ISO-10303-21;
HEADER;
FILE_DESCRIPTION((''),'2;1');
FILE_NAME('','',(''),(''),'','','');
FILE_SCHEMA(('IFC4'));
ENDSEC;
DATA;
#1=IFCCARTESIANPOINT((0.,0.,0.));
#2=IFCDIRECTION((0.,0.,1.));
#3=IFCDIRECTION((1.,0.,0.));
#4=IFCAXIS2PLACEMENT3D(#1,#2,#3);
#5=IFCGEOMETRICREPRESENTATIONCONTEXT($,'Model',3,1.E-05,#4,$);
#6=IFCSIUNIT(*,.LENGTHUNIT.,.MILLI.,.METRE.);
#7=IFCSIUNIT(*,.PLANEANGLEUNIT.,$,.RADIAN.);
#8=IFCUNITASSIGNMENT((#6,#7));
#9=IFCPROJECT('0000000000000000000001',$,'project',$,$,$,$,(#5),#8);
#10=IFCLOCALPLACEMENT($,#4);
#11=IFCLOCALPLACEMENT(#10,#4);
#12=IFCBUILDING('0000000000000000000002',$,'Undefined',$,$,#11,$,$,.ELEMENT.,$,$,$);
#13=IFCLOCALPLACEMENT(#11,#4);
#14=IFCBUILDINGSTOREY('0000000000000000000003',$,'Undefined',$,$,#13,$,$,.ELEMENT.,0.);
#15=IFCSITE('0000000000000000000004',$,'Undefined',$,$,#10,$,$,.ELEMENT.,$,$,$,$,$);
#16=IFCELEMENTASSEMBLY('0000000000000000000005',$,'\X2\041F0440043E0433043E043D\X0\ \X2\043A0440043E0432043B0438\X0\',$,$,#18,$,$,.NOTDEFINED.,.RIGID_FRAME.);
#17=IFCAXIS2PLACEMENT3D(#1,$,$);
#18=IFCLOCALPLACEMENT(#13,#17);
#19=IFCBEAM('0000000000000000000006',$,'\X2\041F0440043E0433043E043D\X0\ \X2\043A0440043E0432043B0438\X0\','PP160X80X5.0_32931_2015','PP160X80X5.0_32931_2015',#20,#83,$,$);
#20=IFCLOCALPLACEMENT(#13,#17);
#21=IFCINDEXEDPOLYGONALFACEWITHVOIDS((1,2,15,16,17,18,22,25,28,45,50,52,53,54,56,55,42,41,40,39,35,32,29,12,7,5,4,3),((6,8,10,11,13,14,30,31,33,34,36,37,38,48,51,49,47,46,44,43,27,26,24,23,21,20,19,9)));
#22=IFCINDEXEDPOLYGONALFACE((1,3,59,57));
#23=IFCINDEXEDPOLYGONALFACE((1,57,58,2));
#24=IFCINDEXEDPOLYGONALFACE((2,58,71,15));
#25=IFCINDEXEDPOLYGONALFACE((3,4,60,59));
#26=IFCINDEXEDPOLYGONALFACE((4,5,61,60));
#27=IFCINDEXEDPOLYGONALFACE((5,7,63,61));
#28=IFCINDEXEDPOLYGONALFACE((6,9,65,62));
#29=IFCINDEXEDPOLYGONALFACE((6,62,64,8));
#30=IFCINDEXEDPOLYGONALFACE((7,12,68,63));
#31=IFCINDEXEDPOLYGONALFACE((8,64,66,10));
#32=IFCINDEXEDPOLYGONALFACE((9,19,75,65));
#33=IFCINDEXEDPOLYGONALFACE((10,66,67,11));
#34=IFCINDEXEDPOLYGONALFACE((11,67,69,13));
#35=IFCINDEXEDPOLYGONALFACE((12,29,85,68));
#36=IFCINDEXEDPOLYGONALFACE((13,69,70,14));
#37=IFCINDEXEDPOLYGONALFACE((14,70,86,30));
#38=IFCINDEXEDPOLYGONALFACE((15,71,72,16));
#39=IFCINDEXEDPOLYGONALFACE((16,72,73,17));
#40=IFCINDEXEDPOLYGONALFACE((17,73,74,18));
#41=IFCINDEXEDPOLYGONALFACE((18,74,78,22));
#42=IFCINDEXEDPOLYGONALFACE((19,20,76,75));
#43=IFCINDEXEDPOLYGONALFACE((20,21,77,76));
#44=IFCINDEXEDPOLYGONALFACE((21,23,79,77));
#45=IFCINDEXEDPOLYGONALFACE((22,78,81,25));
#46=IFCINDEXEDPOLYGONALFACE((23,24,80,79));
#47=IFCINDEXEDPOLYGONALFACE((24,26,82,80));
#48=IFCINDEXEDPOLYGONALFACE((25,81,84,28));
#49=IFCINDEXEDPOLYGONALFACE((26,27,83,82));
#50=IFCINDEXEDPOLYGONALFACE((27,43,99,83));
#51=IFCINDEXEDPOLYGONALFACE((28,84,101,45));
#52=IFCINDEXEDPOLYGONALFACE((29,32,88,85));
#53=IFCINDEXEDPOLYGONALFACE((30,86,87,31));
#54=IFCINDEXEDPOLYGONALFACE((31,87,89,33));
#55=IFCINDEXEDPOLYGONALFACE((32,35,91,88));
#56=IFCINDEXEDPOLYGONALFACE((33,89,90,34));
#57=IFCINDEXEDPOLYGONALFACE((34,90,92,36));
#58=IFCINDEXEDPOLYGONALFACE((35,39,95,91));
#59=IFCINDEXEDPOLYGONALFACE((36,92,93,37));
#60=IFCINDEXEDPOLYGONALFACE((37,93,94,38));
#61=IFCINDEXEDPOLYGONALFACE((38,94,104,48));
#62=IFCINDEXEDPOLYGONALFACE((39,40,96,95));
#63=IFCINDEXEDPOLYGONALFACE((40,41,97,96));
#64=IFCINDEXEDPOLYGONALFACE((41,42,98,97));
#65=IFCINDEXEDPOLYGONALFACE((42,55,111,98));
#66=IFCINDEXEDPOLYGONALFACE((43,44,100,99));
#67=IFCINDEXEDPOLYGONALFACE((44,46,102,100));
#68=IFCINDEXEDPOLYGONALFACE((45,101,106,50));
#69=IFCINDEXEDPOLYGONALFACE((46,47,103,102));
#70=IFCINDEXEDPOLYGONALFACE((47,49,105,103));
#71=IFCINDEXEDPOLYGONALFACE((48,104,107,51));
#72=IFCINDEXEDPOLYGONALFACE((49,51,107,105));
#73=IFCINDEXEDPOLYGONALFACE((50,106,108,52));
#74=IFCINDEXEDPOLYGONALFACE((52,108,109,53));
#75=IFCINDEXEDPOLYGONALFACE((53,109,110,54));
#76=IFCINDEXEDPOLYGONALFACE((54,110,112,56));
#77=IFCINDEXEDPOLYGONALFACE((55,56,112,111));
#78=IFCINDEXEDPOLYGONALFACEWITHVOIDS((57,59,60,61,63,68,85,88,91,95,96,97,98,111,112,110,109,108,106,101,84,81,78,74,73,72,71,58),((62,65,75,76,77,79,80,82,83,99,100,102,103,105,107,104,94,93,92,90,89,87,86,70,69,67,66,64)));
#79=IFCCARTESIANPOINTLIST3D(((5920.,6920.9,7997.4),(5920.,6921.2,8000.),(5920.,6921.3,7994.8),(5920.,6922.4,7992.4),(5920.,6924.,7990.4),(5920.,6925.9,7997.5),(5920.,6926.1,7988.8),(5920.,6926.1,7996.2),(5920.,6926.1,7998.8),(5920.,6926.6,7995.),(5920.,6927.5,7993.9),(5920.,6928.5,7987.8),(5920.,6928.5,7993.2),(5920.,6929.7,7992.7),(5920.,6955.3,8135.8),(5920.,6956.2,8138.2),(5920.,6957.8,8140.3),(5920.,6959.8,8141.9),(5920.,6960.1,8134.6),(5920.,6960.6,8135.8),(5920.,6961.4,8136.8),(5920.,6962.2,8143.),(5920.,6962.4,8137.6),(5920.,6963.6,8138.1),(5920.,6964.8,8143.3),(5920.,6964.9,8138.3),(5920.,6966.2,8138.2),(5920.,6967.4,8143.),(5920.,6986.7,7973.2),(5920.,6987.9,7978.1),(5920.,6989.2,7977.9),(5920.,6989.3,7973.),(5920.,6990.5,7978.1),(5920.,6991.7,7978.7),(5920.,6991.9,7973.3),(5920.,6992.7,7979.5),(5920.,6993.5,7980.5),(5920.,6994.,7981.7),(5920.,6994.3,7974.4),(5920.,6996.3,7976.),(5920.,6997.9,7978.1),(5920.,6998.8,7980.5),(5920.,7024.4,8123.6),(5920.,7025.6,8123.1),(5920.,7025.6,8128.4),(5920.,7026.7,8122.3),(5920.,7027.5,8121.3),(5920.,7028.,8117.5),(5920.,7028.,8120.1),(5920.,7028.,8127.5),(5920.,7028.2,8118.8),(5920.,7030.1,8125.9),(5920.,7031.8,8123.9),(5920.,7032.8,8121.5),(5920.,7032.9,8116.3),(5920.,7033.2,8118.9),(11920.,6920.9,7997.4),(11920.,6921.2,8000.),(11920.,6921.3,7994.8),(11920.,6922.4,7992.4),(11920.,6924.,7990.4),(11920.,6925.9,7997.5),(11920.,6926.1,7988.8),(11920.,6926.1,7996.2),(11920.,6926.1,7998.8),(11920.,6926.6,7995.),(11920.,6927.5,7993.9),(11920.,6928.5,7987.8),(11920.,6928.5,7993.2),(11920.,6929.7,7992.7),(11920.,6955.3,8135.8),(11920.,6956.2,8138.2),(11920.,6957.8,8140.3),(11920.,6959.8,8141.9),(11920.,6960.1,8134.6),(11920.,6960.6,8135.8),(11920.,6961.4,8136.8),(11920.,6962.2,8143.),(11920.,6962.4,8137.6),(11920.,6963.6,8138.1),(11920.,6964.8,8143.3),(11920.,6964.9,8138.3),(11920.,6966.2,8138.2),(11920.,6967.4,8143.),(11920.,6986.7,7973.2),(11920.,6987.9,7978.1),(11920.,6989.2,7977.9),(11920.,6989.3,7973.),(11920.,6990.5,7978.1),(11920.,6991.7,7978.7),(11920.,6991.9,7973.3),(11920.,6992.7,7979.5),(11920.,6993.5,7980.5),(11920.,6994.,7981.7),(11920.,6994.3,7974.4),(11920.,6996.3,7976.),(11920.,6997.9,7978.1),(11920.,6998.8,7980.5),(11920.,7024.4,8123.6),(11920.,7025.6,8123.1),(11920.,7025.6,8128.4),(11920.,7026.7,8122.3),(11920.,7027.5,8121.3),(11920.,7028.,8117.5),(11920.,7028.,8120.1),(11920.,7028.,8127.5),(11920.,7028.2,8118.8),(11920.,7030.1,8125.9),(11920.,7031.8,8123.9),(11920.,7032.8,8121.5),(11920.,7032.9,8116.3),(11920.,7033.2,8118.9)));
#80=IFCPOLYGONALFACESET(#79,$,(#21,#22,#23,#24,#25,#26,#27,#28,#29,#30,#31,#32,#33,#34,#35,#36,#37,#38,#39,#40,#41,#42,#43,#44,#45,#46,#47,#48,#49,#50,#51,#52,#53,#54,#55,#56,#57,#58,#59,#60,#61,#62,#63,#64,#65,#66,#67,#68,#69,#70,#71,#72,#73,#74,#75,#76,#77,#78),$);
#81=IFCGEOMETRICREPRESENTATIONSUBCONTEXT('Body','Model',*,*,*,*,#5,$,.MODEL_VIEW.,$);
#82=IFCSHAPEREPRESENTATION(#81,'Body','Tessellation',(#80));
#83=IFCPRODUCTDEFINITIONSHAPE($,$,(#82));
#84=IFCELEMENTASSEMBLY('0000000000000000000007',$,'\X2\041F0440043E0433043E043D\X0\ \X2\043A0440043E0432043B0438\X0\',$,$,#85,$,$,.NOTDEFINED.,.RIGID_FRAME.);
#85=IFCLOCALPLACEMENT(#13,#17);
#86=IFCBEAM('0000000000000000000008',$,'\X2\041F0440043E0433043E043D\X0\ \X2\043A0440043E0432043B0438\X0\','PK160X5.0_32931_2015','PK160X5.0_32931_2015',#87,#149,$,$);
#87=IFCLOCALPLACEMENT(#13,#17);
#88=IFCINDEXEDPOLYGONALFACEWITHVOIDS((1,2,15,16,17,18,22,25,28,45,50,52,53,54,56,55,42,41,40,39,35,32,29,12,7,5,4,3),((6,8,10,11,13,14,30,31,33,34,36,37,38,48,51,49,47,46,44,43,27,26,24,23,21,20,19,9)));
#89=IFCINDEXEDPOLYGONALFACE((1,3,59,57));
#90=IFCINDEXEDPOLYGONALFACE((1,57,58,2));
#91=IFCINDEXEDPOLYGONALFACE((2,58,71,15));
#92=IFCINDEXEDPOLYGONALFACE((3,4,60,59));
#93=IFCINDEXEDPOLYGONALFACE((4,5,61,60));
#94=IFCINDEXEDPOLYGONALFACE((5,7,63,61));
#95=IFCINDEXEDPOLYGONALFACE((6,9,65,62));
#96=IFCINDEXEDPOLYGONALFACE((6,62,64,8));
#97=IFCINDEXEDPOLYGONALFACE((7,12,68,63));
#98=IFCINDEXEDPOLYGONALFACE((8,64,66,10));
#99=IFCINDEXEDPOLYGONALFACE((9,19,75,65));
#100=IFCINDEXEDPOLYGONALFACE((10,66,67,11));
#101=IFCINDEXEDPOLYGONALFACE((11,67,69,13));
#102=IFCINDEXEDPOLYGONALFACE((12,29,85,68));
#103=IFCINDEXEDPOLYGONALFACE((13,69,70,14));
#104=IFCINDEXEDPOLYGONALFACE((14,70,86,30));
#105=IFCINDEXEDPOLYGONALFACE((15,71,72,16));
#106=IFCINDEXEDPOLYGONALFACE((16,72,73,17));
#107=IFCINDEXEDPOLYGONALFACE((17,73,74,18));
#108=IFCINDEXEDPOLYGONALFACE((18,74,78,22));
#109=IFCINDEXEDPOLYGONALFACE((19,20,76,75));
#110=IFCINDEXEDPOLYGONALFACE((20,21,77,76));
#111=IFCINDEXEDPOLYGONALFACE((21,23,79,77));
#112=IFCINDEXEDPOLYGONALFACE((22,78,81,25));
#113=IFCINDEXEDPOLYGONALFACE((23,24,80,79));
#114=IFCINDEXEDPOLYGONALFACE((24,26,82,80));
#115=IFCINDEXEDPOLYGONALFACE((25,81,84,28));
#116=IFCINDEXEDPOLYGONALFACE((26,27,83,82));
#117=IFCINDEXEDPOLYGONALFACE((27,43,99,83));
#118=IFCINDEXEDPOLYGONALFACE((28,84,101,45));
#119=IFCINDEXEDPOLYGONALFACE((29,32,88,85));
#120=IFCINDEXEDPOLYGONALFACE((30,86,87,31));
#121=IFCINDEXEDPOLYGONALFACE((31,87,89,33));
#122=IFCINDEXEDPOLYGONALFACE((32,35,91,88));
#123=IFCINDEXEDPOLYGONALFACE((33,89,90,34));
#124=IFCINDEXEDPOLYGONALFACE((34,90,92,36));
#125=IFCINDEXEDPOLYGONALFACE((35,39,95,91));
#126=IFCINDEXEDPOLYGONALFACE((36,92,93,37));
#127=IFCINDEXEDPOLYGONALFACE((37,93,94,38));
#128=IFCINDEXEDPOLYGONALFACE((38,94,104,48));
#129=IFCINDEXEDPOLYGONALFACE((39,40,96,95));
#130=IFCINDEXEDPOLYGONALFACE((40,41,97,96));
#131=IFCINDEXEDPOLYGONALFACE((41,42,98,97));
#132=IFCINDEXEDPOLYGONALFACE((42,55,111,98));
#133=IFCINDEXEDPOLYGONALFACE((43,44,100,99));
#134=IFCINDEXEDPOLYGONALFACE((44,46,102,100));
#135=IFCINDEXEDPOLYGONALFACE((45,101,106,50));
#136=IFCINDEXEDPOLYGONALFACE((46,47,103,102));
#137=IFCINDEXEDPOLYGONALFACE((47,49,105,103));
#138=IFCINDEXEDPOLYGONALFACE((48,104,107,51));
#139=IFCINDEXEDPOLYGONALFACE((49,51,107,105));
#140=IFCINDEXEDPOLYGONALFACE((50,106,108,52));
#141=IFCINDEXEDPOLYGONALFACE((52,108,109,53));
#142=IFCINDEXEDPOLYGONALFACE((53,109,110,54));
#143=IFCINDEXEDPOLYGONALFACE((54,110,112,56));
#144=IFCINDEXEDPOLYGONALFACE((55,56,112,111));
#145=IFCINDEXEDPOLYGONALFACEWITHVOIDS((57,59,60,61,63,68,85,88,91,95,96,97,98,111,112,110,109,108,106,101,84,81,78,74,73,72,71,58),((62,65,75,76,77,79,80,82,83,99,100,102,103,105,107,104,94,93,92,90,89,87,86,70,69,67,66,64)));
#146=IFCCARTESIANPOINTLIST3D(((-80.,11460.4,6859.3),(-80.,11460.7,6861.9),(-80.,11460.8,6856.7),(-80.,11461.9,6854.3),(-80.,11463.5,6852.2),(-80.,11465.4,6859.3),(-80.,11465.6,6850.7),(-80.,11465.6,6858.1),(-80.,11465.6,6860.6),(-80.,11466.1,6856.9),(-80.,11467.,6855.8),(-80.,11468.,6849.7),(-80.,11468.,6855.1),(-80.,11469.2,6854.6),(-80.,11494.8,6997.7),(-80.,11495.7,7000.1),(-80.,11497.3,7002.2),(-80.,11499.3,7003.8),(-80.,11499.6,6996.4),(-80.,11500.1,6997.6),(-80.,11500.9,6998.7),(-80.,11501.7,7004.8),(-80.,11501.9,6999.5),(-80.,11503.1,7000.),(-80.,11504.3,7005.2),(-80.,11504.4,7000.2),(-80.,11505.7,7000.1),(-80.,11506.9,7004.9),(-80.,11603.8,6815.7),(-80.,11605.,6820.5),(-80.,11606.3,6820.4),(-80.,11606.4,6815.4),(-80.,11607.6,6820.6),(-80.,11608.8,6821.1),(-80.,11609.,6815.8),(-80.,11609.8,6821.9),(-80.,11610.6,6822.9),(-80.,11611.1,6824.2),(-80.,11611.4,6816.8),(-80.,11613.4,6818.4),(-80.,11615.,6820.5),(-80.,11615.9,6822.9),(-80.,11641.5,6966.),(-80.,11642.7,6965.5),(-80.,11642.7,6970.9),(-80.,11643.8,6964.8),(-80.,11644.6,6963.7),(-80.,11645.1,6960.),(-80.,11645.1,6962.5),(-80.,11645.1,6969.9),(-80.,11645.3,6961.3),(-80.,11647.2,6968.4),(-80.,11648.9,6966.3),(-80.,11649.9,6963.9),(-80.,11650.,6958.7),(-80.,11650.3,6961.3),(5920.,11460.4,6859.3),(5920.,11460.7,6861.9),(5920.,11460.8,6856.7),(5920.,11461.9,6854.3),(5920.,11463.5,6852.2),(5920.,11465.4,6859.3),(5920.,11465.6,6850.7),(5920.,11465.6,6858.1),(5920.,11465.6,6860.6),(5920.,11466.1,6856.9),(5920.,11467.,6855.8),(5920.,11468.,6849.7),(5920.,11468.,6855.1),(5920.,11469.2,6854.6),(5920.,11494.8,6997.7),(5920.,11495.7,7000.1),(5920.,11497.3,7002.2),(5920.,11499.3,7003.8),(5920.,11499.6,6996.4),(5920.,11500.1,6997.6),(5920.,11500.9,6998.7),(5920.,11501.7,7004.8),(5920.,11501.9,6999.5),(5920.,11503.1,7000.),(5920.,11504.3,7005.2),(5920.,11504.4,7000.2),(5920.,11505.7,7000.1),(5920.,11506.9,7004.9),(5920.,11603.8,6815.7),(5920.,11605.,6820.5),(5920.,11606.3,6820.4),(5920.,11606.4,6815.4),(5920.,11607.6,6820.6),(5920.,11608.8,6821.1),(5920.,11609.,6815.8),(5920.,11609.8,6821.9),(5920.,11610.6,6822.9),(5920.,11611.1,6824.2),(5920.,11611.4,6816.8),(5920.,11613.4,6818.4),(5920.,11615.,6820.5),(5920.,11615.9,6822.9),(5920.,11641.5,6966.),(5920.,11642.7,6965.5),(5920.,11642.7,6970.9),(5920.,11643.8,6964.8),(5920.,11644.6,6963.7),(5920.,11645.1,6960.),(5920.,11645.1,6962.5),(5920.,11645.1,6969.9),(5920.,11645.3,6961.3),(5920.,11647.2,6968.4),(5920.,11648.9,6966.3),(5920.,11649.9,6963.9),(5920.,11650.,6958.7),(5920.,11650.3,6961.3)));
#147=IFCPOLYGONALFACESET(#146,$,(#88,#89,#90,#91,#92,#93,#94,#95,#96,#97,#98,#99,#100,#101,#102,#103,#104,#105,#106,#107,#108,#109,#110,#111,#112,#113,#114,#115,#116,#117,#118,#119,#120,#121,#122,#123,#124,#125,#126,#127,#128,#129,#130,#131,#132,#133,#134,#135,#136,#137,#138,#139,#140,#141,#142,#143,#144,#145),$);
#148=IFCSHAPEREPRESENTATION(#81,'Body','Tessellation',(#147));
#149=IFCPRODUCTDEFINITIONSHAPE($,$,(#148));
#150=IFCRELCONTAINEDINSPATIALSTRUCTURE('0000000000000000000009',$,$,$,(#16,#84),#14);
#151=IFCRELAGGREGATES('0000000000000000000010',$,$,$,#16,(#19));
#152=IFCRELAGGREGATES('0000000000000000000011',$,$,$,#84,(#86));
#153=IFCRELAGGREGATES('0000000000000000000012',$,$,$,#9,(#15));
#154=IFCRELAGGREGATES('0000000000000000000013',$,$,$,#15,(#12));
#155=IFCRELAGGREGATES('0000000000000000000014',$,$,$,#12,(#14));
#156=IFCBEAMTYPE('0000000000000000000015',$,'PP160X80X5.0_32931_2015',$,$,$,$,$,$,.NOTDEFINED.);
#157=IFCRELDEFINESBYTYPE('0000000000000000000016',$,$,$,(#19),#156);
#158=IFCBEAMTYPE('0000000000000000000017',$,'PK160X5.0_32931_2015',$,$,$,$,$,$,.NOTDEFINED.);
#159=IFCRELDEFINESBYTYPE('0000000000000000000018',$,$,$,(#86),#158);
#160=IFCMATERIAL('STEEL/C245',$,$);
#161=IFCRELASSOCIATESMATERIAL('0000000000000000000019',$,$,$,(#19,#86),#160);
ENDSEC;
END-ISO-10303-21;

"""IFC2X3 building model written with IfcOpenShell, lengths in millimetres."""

from ifc_helpers import new_model, si_unit, frame, origin_with_axes, origin_2d_with_axis, place, context, subcontext, project, spatial, hollow_rectangle, extrude, material, type_object, element, aggregate, save


model = new_model("IFC2X3")

# Units and contexts
model_context = context("Model", 3, precision=1e-05, world=origin_with_axes())
body_context = subcontext(model_context, "Body", "Model", "MODEL_VIEW")
ifc_project = project(units=[si_unit("LENGTHUNIT", "METRE", prefix="MILLI"), si_unit("PLANEANGLEUNIT", "RADIAN")], contexts=[model_context])

# Site, building, storey
site_placement = place(None, origin_with_axes())
site = spatial("IfcSite", under=ifc_project, at=site_placement, Name="Undefined", CompositionType="ELEMENT")
building_placement = place(site_placement, origin_with_axes())
building = spatial("IfcBuilding", under=site, at=building_placement, Name="Undefined", CompositionType="ELEMENT")
storey_placement = place(building_placement, origin_with_axes())
storey = spatial("IfcBuildingStorey", under=building, at=storey_placement, Name="Undefined", CompositionType="ELEMENT", Elevation=0.0)

# Shared definitions
ifc_material = material(Name="STEEL/C245")

# Element assemblies, beams
beam_type_1 = type_object("IfcBeamType", Name="PP160X80X5.0_32931_2015", PredefinedType="NOTDEFINED")
assembly_1_placement = place(storey_placement, origin_with_axes())
assembly_1 = element("IfcElementAssembly", 1, at=assembly_1_placement, inside=storey, Name="Прогон кровли", AssemblyPlace="NOTDEFINED", PredefinedType="RIGID_FRAME")
beam_1_placement = place(assembly_1_placement, frame((5920.0, 6977.1, 8058.1), z_axis=(0.0, 0.243188, 0.969979), x_axis=(1.0, 0.0, 0.0)))
beam_1 = element("IfcBeam", 2, at=beam_1_placement, type_object=beam_type_1, material=ifc_material, Name="Прогон кровли", Description="PP160X80X5.0_32931_2015", ObjectType="PP160X80X5.0_32931_2015", context=body_context, shape_type="SweptSolid", body=[
    extrude(hollow_rectangle(XDim=80.0, YDim=160.0, WallThickness=5.0, InnerFilletRadius=5.0, OuterFilletRadius=10.0, at=origin_2d_with_axis()), frame((6000.0, 0.0, 0.0), z_axis=(-1.0, 0.0, 0.0), x_axis=(0.0, -1.0, 0.0)), (0.0, 0.0, 1.0), 6000.0),
])
aggregate(assembly_1, [beam_1])
assembly_2_placement = place(storey_placement, origin_with_axes())
assembly_2 = element("IfcElementAssembly", 3, at=assembly_2_placement, inside=storey, Name="Прогон кровли", AssemblyPlace="NOTDEFINED", PredefinedType="RIGID_FRAME")
beam_type_2 = type_object("IfcBeamType", Name="PK160X5.0_32931_2015", PredefinedType="NOTDEFINED")
beam_2_placement = place(assembly_2_placement, frame((-80.0, 11555.4, 6910.3), z_axis=(0.0, 0.243188, 0.969979), x_axis=(1.0, 0.0, 0.0)))
beam_2 = element("IfcBeam", 4, at=beam_2_placement, type_object=beam_type_2, material=ifc_material, Name="Прогон кровли", Description="PK160X5.0_32931_2015", ObjectType="PK160X5.0_32931_2015", context=body_context, shape_type="SweptSolid", body=[
    extrude(hollow_rectangle(XDim=160.0, YDim=160.0, WallThickness=5.0, InnerFilletRadius=5.0, OuterFilletRadius=10.0, at=origin_2d_with_axis()), frame((6000.0, 0.0, 0.0), z_axis=(-1.0, 0.0, 0.0), x_axis=(0.0, -1.0, 0.0)), (0.0, 0.0, 1.0), 6000.0),
])
aggregate(assembly_2, [beam_2])

save(model, "model.ifc")
